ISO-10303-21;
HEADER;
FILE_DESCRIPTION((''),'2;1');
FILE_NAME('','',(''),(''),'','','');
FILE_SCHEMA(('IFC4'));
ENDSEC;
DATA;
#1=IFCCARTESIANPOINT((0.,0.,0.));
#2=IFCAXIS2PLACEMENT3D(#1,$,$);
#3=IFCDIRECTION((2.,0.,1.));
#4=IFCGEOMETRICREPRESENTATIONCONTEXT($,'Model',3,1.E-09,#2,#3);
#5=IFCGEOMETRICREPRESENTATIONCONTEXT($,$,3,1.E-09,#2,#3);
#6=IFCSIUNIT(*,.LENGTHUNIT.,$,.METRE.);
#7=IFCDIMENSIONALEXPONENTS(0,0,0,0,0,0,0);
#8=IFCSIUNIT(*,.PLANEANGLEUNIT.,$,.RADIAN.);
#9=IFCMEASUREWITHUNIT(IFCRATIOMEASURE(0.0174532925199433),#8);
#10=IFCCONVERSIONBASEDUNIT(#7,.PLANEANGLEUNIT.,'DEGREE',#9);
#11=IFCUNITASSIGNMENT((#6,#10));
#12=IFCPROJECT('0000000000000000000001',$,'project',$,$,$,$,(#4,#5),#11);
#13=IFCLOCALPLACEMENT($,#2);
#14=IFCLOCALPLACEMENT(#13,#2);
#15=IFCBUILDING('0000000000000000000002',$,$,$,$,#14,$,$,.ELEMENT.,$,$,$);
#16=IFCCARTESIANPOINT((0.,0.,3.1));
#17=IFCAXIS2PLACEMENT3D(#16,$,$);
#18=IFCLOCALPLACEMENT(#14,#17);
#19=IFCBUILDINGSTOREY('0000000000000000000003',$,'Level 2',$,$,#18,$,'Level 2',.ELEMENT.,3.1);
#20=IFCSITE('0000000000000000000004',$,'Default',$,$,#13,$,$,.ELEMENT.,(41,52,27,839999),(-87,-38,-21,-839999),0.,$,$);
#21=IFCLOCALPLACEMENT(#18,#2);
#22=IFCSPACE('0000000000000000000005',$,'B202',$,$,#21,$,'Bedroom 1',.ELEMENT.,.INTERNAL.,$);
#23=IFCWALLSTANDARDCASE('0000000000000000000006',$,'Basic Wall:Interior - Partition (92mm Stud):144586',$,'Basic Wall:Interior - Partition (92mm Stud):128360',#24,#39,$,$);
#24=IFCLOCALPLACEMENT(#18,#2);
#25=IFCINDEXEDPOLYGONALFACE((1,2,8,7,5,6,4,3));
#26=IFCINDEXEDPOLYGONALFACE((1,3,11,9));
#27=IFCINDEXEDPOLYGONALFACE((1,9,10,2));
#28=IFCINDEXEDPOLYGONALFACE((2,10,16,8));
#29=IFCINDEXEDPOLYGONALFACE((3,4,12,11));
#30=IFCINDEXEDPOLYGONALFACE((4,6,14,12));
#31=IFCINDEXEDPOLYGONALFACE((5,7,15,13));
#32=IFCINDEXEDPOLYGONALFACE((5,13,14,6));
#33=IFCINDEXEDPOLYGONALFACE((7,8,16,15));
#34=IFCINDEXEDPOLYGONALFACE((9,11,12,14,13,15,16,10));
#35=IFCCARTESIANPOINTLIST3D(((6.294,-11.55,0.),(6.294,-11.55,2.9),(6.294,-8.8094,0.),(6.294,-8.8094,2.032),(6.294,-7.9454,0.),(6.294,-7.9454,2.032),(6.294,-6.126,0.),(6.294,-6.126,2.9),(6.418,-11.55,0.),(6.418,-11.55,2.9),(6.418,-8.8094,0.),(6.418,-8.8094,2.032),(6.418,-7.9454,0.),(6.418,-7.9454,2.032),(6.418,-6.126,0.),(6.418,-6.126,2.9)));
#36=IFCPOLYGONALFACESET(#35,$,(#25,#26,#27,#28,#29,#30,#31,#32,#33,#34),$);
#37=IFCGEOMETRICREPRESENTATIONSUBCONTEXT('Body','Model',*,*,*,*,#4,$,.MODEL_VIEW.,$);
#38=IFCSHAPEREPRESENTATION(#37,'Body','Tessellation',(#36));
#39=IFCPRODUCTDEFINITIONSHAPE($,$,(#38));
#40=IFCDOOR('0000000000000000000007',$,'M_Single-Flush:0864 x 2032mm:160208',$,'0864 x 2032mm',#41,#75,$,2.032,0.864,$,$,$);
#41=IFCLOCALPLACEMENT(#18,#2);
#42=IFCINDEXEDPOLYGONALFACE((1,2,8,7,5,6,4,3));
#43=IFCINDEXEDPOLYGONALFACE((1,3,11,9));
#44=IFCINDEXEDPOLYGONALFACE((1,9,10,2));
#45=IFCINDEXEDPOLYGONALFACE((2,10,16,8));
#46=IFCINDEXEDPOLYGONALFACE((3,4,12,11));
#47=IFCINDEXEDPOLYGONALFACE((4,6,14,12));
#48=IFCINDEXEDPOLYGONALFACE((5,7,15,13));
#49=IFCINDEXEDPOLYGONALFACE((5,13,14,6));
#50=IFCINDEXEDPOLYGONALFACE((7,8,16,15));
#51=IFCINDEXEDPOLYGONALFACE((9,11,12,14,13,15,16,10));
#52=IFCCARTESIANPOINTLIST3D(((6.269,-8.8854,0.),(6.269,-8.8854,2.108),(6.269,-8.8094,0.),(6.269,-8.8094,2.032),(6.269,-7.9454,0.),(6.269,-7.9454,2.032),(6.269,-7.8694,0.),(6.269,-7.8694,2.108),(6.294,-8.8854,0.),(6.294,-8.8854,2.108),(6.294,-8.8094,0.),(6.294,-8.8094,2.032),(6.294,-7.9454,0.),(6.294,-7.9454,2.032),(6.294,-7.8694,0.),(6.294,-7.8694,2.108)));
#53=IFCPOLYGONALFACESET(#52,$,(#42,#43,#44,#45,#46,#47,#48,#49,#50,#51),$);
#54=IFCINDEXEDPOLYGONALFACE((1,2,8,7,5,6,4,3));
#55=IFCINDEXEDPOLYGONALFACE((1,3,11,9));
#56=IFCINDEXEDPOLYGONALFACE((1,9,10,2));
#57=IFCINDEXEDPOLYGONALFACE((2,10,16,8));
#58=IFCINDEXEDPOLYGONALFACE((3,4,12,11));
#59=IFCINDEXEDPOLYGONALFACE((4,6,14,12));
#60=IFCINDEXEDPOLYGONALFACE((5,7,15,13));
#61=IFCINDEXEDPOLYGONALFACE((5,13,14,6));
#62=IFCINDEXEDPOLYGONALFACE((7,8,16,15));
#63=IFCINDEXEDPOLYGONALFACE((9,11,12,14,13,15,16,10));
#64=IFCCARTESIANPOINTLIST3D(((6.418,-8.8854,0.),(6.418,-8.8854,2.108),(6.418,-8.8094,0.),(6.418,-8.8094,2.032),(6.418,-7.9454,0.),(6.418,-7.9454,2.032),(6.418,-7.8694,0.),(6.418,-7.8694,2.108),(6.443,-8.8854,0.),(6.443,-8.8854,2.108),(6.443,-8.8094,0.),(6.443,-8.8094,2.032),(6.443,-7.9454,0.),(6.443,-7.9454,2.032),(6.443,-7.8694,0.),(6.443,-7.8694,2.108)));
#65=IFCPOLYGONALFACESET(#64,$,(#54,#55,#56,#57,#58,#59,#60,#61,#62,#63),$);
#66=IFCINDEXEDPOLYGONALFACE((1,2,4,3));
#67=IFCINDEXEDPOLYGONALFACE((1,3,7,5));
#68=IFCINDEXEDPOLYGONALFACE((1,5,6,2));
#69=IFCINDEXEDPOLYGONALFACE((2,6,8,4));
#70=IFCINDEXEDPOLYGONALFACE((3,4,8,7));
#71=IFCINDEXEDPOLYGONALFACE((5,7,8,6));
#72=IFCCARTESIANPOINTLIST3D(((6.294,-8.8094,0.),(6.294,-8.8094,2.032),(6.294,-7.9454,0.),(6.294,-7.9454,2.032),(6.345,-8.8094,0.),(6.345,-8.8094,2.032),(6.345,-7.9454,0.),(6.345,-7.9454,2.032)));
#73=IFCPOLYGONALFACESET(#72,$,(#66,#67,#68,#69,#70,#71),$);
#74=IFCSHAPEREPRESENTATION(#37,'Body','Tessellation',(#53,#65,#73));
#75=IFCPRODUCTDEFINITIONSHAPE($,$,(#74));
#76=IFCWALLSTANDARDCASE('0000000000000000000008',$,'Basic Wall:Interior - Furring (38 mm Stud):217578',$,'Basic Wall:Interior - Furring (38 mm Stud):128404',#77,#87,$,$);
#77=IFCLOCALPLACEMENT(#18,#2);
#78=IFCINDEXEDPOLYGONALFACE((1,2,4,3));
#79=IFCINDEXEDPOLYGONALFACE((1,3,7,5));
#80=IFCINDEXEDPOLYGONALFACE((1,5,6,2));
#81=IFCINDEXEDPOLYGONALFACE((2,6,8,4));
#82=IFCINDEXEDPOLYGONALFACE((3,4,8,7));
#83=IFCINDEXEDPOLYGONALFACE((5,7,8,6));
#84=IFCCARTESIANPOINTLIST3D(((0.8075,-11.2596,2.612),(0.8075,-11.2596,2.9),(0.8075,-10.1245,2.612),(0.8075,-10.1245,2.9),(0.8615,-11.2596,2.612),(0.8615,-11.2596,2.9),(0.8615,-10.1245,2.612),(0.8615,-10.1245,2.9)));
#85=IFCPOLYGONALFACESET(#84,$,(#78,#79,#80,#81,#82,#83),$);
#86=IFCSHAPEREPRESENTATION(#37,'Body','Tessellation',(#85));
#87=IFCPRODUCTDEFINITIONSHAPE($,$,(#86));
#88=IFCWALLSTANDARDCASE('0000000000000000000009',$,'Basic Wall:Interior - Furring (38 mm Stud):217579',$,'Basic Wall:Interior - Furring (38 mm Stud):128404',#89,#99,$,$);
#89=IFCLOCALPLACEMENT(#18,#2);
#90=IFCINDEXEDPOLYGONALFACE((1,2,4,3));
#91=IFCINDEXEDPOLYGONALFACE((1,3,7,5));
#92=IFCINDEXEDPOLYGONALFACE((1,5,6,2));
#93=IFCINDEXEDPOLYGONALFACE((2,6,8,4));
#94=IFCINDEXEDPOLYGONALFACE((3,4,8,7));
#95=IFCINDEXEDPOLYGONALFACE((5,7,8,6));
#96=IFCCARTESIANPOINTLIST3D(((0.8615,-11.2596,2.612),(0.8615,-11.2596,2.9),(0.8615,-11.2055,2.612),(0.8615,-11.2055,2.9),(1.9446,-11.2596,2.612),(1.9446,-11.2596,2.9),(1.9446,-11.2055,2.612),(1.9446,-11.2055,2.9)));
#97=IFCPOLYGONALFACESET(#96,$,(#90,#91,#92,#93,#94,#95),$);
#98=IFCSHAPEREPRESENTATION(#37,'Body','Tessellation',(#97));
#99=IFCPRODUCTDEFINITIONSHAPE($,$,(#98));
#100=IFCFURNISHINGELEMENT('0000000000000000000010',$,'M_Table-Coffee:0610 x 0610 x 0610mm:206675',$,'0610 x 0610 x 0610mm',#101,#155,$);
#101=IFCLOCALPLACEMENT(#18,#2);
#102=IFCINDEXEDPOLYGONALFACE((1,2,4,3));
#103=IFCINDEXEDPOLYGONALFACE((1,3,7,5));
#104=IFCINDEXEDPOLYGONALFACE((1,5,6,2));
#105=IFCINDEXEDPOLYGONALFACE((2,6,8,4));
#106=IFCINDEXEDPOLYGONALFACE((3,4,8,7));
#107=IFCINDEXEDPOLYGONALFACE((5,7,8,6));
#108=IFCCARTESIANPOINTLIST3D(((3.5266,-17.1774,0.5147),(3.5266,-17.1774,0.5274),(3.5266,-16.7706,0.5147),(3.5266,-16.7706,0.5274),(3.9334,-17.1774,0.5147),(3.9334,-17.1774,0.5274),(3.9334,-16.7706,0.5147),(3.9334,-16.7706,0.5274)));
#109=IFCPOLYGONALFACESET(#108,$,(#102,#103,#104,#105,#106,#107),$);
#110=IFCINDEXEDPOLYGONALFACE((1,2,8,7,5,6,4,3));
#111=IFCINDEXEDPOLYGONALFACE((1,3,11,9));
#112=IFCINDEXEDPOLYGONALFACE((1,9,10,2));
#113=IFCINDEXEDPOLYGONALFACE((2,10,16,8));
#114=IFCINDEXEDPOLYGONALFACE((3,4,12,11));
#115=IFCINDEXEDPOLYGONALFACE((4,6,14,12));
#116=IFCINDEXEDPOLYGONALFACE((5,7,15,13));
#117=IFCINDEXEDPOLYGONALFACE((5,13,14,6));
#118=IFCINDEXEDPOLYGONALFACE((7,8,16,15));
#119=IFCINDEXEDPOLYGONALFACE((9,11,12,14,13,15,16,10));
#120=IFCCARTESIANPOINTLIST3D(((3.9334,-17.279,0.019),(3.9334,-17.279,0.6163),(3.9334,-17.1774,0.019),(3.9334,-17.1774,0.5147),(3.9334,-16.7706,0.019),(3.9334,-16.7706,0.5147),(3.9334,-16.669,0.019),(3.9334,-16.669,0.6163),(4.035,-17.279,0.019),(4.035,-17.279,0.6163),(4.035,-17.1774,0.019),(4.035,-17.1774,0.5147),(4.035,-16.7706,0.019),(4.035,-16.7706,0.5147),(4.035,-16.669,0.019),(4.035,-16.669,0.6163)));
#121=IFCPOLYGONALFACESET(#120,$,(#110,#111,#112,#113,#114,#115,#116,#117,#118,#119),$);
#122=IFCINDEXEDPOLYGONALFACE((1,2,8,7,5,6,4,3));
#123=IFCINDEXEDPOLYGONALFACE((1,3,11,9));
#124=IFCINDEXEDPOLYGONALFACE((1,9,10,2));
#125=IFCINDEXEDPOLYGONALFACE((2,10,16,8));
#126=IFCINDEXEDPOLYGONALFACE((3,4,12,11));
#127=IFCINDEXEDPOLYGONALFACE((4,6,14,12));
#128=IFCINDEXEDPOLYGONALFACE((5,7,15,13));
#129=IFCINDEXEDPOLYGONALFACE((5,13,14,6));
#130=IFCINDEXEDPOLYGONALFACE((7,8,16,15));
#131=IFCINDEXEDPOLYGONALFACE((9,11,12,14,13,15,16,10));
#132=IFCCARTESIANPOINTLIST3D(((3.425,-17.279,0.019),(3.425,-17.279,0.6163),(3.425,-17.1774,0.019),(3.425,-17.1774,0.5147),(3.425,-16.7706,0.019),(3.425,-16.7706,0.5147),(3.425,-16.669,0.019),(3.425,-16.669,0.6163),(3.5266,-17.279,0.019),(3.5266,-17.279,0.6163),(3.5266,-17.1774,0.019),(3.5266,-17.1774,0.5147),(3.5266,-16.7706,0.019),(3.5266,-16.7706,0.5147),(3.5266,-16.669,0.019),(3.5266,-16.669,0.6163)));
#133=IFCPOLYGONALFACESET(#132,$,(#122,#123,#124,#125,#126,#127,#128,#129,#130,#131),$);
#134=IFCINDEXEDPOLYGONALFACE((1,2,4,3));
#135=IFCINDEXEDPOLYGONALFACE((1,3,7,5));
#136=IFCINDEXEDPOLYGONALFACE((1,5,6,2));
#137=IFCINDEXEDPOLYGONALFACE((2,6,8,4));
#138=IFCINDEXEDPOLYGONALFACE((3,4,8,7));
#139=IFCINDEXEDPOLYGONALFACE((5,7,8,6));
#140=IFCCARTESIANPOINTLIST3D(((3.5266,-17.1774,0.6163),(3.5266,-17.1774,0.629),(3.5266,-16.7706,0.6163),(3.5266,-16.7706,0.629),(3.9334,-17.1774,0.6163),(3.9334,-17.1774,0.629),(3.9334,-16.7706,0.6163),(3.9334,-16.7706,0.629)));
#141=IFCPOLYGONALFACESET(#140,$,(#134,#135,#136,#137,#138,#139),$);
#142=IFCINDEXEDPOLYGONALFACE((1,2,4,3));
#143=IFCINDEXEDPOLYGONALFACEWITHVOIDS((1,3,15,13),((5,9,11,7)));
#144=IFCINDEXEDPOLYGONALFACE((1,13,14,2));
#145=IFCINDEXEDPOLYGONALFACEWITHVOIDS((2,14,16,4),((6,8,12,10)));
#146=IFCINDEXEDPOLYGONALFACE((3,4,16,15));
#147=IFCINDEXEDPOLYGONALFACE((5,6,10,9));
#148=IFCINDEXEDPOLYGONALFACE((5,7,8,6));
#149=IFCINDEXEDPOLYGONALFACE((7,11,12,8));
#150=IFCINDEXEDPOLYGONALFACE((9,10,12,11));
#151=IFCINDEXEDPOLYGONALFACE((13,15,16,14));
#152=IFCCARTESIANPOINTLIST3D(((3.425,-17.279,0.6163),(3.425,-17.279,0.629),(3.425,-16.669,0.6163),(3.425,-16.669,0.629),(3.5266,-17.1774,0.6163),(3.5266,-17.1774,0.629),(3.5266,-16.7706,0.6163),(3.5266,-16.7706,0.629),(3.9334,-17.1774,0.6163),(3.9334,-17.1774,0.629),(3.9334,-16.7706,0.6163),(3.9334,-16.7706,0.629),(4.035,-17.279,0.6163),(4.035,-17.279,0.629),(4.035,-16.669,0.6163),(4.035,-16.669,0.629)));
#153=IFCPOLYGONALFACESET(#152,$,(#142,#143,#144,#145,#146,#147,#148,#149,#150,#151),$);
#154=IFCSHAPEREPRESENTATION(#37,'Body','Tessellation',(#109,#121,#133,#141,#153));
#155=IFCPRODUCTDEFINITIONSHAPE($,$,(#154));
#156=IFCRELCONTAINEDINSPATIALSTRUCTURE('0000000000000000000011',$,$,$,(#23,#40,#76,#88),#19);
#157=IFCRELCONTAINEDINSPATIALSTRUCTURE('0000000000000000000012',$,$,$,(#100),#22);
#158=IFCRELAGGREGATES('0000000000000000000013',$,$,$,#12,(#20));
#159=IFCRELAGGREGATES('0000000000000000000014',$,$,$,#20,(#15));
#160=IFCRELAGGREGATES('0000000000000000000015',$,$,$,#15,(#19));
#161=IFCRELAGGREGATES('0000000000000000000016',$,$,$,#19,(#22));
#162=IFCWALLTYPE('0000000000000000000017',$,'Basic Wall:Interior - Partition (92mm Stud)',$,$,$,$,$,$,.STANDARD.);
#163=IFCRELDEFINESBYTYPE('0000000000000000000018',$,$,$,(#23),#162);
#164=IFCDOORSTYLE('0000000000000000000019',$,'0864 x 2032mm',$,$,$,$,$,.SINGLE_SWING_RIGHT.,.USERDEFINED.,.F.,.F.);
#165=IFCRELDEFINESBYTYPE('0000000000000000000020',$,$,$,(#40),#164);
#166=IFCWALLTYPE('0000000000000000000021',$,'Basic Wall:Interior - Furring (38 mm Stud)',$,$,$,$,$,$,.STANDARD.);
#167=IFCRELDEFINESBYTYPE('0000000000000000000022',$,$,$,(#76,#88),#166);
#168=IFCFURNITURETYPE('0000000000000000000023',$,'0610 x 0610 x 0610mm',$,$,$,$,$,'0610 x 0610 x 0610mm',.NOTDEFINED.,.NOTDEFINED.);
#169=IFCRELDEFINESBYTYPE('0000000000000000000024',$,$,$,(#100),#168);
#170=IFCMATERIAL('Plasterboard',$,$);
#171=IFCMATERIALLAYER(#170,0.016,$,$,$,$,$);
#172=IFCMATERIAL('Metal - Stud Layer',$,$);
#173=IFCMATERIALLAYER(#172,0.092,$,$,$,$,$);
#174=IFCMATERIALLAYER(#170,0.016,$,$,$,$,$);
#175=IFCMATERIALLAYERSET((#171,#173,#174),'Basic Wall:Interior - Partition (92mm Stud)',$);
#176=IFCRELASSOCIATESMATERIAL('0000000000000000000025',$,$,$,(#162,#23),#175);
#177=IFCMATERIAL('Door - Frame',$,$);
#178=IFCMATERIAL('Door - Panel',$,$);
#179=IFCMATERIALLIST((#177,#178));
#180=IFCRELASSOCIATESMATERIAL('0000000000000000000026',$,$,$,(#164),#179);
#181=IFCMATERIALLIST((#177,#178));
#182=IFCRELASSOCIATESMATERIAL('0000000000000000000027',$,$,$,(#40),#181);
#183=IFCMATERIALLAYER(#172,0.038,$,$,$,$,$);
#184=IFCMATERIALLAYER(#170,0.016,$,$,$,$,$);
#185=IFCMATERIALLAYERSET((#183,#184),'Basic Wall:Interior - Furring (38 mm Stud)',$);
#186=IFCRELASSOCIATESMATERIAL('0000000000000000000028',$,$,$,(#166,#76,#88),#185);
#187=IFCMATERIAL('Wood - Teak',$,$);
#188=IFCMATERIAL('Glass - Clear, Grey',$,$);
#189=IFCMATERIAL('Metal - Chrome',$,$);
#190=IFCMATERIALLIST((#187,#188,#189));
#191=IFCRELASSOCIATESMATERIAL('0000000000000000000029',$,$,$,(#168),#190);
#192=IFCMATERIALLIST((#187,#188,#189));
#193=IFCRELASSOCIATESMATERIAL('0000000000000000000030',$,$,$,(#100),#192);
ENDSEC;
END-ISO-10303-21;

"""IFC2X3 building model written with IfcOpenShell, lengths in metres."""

from ifc_helpers import new_model, entity, si_unit, converted_unit, direction, frame, frame_2d, origin, origin_2d_with_axis, place, context, subcontext, project, spatial, polyline, rectangle, outline, extrude, source, transform, mapped, material, material_list, layer, layer_set, layer_usage, type_object, type_shapes, element, fill, save


model = new_model("IFC2X3")

# Units and contexts
model_context = context("Model", 3, precision=1e-09, world=origin(), true_north=direction((2.0, 0.0, 1.0)))
context_of_model = context(None, 3, precision=1e-09, world=origin(), true_north=direction((2.0, 0.0, 1.0)))
body_context = subcontext(model_context, "Body", "Model", "MODEL_VIEW")
ifc_project = project(units=[si_unit("LENGTHUNIT", "METRE"), converted_unit("PLANEANGLEUNIT", "DEGREE", entity("IfcRatioMeasure", 0.0174532925199433), si_unit("PLANEANGLEUNIT", "RADIAN"), dimensions=[0, 0, 0, 0, 0, 0, 0])], contexts=[model_context, context_of_model])

# Site, building, storey
site_placement = place(None, origin())
site = spatial("IfcSite", under=ifc_project, at=site_placement, Name="Default", CompositionType="ELEMENT", RefLatitude=(41, 52, 27, 839999), RefLongitude=(-87, -38, -21, -839999), RefElevation=0.0)
building_placement = place(site_placement, origin())
building = spatial("IfcBuilding", under=site, at=building_placement, CompositionType="ELEMENT")
storey_placement = place(building_placement, frame((0.0, 0.0, 3.1)))
storey = spatial("IfcBuildingStorey", under=building, at=storey_placement, Name="Level 2", LongName="Level 2", CompositionType="ELEMENT", Elevation=3.1)

# Shared definitions
ifc_material_1 = material(Name="Metal - Stud Layer")
ifc_material_2 = material(Name="Plasterboard")

# Wall, opening, door
ifc_layer_1 = layer(ifc_material_2, 0.016)
ifc_layer_2 = layer(ifc_material_1, 0.092)
ifc_layer_3 = layer(ifc_material_2, 0.016)
ifc_layer_set_1 = layer_set([ifc_layer_1, ifc_layer_2, ifc_layer_3], Name="Basic Wall:Interior - Partition (92mm Stud)")
wall_type_1 = type_object("IfcWallType", Name="Basic Wall:Interior - Partition (92mm Stud)", PredefinedType="STANDARD", material=ifc_layer_set_1)
ifc_material_3 = material(Name="Door - Frame")
ifc_material_4 = material(Name="Door - Panel")
ifc_layer_usage_1 = layer_usage(ifc_layer_set_1, "AXIS2", "NEGATIVE", 0.062)
wall_1_placement = place(storey_placement, frame((6.356, -11.55, 0.0), z_axis=(0.0, 0.0, 1.0), x_axis=(0.0, 1.0, 0.0)))
wall_1 = element("IfcWallStandardCase", 1, at=wall_1_placement, inside=storey, type_object=wall_type_1, material=ifc_layer_usage_1, Name="Basic Wall:Interior - Partition (92mm Stud):144586", ObjectType="Basic Wall:Interior - Partition (92mm Stud):128360", context=body_context, shape_type="SweptSolid", body=[
    extrude(rectangle(XDim=5.424, YDim=0.124, at=frame_2d((2.712, 0.0), x_axis=(-1.0, 0.0))), origin(), (0.0, 0.0, 1.0), 2.9),
])
opening_1_placement = place(wall_1_placement, frame((2.7406, -0.062, 0.0)))
opening_1 = element("IfcOpeningElement", 2, at=opening_1_placement, cuts=wall_1, ObjectType="Opening", context=body_context, shape_type="SweptSolid", body=[
    extrude(rectangle(XDim=0.864, YDim=2.032, at=frame_2d((1.016, 0.432), x_axis=(0.0, 1.0))), frame((0.0, 0.0, 0.0), z_axis=(0.0, 1.0, 0.0), x_axis=(0.0, 0.0, 1.0)), (0.0, 0.0, 1.0), 0.124),
])
ifc_material_list_1 = material_list([ifc_material_3, ifc_material_4])
ifc_material_list_2 = material_list([ifc_material_3, ifc_material_4])
door_style_1 = type_object("IfcDoorStyle", Name="0864 x 2032mm", ConstructionType="USERDEFINED", OperationType="SINGLE_SWING_RIGHT", ParameterTakesPrecedence=False, Sizeable=False, material=ifc_material_list_2)
shared_shape_1 = source(origin(), body_context, "Body", "SweptSolid", [
    extrude(outline(polyline([(-0.508, -1.073), (0.508, -1.073), (0.508, 1.035), (0.432, 1.035), (0.432, -0.997), (-0.432, -0.997), (-0.432, 1.035), (-0.508, 1.035), (-0.508, -1.073)])), frame((0.432, 0.124, 1.035), z_axis=(0.0, 1.0, 0.0), x_axis=(1.0, 0.0, 0.0)), (0.0, 0.0, 1.0), 0.025),
    extrude(outline(polyline([(-1.073, -0.508), (1.035, -0.508), (1.035, -0.432), (-0.997, -0.432), (-0.997, 0.432), (1.035, 0.432), (1.035, 0.508), (-1.073, 0.508), (-1.073, -0.508)])), frame((0.432, -0.025, 1.035), z_axis=(0.0, 1.0, 0.0), x_axis=(0.0, 0.0, -1.0)), (0.0, 0.0, 1.0), 0.025),
    extrude(rectangle(XDim=0.051, YDim=0.864, at=origin_2d_with_axis()), frame((0.432, 0.0985, 0.0), z_axis=(0.0, 0.0, 1.0), x_axis=(0.0, 1.0, 0.0)), (0.0, 0.0, 1.0), 2.032),
])
type_shapes(door_style_1, [shared_shape_1])
door_1_placement = place(opening_1_placement, origin())
door_1 = element("IfcDoor", 3, at=door_1_placement, inside=storey, type_object=door_style_1, material=ifc_material_list_1, Name="M_Single-Flush:0864 x 2032mm:160208", ObjectType="0864 x 2032mm", OverallHeight=2.032, OverallWidth=0.864, context=body_context, shape_type="MappedRepresentation", body=[
    mapped(shared_shape_1, transform((0.0, 0.0, 0.0), scale=1.0)),
])
fill(opening_1, door_1)

# Walls
ifc_layer_4 = layer(ifc_material_1, 0.038)
ifc_layer_5 = layer(ifc_material_2, 0.016)
ifc_layer_set_2 = layer_set([ifc_layer_4, ifc_layer_5], Name="Basic Wall:Interior - Furring (38 mm Stud)")
ifc_layer_usage_2 = layer_usage(ifc_layer_set_2, "AXIS2", "NEGATIVE", 0.027)
wall_type_2 = type_object("IfcWallType", Name="Basic Wall:Interior - Furring (38 mm Stud)", PredefinedType="STANDARD", material=ifc_layer_set_2)
wall_2_placement = place(storey_placement, frame((0.8345, -11.2596, 2.612), z_axis=(0.0, 0.0, 1.0), x_axis=(0.0, 1.0, 0.0)))
element("IfcWallStandardCase", 4, at=wall_2_placement, inside=storey, type_object=wall_type_2, material=ifc_layer_usage_2, Name="Basic Wall:Interior - Furring (38 mm Stud):217578", ObjectType="Basic Wall:Interior - Furring (38 mm Stud):128404", context=body_context, shape_type="SweptSolid", body=[
    extrude(rectangle(XDim=1.1351, YDim=0.054, at=frame_2d((0.5675, 0.0), x_axis=(-1.0, 0.0))), origin(), (0.0, 0.0, 1.0), 0.288),
])
ifc_layer_usage_3 = layer_usage(ifc_layer_set_2, "AXIS2", "NEGATIVE", 0.027)
wall_3_placement = place(storey_placement, frame((1.9446, -11.2325, 2.612), z_axis=(0.0, 0.0, 1.0), x_axis=(-1.0, 0.0, 0.0)))
element("IfcWallStandardCase", 5, at=wall_3_placement, inside=storey, type_object=wall_type_2, material=ifc_layer_usage_3, Name="Basic Wall:Interior - Furring (38 mm Stud):217579", ObjectType="Basic Wall:Interior - Furring (38 mm Stud):128404", context=body_context, shape_type="SweptSolid", body=[
    extrude(rectangle(XDim=1.0831, YDim=0.054, at=frame_2d((0.5415, 0.0), x_axis=(-1.0, 0.0))), origin(), (0.0, 0.0, 1.0), 0.288),
])

# Shared definitions
space_1_placement = place(storey_placement, origin())
space_1 = spatial("IfcSpace", under=storey, at=space_1_placement, Name="B202", LongName="Bedroom 1", CompositionType="ELEMENT", InteriorOrExteriorSpace="INTERNAL")

# Furnishing element
ifc_material_5 = material(Name="Wood - Teak")
ifc_material_6 = material(Name="Glass - Clear, Grey")
ifc_material_7 = material(Name="Metal - Chrome")
ifc_material_list_3 = material_list([ifc_material_5, ifc_material_6, ifc_material_7])
ifc_material_list_4 = material_list([ifc_material_5, ifc_material_6, ifc_material_7])
furniture_type_1 = type_object("IfcFurnitureType", Name="0610 x 0610 x 0610mm", ElementType="0610 x 0610 x 0610mm", AssemblyPlace="NOTDEFINED", material=ifc_material_list_4)
shared_shape_2 = source(origin(), body_context, "Body", "SweptSolid", [
    extrude(rectangle(XDim=0.4068, YDim=0.4068, at=origin_2d_with_axis()), frame((0.0183, 0.0952, 0.4957), z_axis=(0.0, 0.0, 1.0), x_axis=(-1.0, 0.0, 0.0)), (0.0, 0.0, 1.0), 0.0127),
    extrude(outline(polyline([(-0.2732, -0.305), (0.324, -0.305), (0.324, 0.305), (-0.2732, 0.305), (-0.2732, 0.2034), (0.2225, 0.2034), (0.2225, -0.2034), (-0.2732, -0.2034), (-0.2732, -0.305)])), frame((0.2217, 0.0952, 0.2732), z_axis=(1.0, 0.0, 0.0), x_axis=(0.0, 0.0, 1.0)), (0.0, 0.0, 1.0), 0.1016),
    extrude(outline(polyline([(-0.305, -0.3241), (0.305, -0.3241), (0.305, 0.2733), (0.2034, 0.2733), (0.2034, -0.2224), (-0.2034, -0.2224), (-0.2034, 0.2733), (-0.305, 0.2733), (-0.305, -0.3241)])), frame((-0.2867, 0.0952, 0.2733), z_axis=(1.0, 0.0, 0.0), x_axis=(0.0, -1.0, 0.0)), (0.0, 0.0, 1.0), 0.1016),
    extrude(rectangle(XDim=0.4068, YDim=0.4068, at=origin_2d_with_axis()), frame((0.0183, 0.0952, 0.5973), z_axis=(0.0, 0.0, 1.0), x_axis=(-1.0, 0.0, 0.0)), (0.0, 0.0, 1.0), 0.0127),
    extrude(outline(polyline([(-0.305, -0.305), (0.305, -0.305), (0.305, 0.305), (-0.305, 0.305), (-0.305, -0.305)]), holes=[polyline([(-0.2034, -0.2034), (-0.2034, 0.2034), (0.2034, 0.2034), (0.2034, -0.2034), (-0.2034, -0.2034)])]), frame((0.0183, 0.0952, 0.5973), z_axis=(0.0, 0.0, 1.0), x_axis=(-1.0, 0.0, 0.0)), (0.0, 0.0, 1.0), 0.0127),
])
type_shapes(furniture_type_1, [shared_shape_2])
furnishing_1_placement = place(space_1_placement, frame((3.7117, -17.0692, 0.019)))
element("IfcFurnishingElement", 6, at=furnishing_1_placement, inside=space_1, type_object=furniture_type_1, material=ifc_material_list_3, Name="M_Table-Coffee:0610 x 0610 x 0610mm:206675", ObjectType="0610 x 0610 x 0610mm", context=body_context, shape_type="MappedRepresentation", body=[
    mapped(shared_shape_2, transform((0.0, 0.0, 0.0), scale=1.0)),
])

save(model, "model.ifc")
